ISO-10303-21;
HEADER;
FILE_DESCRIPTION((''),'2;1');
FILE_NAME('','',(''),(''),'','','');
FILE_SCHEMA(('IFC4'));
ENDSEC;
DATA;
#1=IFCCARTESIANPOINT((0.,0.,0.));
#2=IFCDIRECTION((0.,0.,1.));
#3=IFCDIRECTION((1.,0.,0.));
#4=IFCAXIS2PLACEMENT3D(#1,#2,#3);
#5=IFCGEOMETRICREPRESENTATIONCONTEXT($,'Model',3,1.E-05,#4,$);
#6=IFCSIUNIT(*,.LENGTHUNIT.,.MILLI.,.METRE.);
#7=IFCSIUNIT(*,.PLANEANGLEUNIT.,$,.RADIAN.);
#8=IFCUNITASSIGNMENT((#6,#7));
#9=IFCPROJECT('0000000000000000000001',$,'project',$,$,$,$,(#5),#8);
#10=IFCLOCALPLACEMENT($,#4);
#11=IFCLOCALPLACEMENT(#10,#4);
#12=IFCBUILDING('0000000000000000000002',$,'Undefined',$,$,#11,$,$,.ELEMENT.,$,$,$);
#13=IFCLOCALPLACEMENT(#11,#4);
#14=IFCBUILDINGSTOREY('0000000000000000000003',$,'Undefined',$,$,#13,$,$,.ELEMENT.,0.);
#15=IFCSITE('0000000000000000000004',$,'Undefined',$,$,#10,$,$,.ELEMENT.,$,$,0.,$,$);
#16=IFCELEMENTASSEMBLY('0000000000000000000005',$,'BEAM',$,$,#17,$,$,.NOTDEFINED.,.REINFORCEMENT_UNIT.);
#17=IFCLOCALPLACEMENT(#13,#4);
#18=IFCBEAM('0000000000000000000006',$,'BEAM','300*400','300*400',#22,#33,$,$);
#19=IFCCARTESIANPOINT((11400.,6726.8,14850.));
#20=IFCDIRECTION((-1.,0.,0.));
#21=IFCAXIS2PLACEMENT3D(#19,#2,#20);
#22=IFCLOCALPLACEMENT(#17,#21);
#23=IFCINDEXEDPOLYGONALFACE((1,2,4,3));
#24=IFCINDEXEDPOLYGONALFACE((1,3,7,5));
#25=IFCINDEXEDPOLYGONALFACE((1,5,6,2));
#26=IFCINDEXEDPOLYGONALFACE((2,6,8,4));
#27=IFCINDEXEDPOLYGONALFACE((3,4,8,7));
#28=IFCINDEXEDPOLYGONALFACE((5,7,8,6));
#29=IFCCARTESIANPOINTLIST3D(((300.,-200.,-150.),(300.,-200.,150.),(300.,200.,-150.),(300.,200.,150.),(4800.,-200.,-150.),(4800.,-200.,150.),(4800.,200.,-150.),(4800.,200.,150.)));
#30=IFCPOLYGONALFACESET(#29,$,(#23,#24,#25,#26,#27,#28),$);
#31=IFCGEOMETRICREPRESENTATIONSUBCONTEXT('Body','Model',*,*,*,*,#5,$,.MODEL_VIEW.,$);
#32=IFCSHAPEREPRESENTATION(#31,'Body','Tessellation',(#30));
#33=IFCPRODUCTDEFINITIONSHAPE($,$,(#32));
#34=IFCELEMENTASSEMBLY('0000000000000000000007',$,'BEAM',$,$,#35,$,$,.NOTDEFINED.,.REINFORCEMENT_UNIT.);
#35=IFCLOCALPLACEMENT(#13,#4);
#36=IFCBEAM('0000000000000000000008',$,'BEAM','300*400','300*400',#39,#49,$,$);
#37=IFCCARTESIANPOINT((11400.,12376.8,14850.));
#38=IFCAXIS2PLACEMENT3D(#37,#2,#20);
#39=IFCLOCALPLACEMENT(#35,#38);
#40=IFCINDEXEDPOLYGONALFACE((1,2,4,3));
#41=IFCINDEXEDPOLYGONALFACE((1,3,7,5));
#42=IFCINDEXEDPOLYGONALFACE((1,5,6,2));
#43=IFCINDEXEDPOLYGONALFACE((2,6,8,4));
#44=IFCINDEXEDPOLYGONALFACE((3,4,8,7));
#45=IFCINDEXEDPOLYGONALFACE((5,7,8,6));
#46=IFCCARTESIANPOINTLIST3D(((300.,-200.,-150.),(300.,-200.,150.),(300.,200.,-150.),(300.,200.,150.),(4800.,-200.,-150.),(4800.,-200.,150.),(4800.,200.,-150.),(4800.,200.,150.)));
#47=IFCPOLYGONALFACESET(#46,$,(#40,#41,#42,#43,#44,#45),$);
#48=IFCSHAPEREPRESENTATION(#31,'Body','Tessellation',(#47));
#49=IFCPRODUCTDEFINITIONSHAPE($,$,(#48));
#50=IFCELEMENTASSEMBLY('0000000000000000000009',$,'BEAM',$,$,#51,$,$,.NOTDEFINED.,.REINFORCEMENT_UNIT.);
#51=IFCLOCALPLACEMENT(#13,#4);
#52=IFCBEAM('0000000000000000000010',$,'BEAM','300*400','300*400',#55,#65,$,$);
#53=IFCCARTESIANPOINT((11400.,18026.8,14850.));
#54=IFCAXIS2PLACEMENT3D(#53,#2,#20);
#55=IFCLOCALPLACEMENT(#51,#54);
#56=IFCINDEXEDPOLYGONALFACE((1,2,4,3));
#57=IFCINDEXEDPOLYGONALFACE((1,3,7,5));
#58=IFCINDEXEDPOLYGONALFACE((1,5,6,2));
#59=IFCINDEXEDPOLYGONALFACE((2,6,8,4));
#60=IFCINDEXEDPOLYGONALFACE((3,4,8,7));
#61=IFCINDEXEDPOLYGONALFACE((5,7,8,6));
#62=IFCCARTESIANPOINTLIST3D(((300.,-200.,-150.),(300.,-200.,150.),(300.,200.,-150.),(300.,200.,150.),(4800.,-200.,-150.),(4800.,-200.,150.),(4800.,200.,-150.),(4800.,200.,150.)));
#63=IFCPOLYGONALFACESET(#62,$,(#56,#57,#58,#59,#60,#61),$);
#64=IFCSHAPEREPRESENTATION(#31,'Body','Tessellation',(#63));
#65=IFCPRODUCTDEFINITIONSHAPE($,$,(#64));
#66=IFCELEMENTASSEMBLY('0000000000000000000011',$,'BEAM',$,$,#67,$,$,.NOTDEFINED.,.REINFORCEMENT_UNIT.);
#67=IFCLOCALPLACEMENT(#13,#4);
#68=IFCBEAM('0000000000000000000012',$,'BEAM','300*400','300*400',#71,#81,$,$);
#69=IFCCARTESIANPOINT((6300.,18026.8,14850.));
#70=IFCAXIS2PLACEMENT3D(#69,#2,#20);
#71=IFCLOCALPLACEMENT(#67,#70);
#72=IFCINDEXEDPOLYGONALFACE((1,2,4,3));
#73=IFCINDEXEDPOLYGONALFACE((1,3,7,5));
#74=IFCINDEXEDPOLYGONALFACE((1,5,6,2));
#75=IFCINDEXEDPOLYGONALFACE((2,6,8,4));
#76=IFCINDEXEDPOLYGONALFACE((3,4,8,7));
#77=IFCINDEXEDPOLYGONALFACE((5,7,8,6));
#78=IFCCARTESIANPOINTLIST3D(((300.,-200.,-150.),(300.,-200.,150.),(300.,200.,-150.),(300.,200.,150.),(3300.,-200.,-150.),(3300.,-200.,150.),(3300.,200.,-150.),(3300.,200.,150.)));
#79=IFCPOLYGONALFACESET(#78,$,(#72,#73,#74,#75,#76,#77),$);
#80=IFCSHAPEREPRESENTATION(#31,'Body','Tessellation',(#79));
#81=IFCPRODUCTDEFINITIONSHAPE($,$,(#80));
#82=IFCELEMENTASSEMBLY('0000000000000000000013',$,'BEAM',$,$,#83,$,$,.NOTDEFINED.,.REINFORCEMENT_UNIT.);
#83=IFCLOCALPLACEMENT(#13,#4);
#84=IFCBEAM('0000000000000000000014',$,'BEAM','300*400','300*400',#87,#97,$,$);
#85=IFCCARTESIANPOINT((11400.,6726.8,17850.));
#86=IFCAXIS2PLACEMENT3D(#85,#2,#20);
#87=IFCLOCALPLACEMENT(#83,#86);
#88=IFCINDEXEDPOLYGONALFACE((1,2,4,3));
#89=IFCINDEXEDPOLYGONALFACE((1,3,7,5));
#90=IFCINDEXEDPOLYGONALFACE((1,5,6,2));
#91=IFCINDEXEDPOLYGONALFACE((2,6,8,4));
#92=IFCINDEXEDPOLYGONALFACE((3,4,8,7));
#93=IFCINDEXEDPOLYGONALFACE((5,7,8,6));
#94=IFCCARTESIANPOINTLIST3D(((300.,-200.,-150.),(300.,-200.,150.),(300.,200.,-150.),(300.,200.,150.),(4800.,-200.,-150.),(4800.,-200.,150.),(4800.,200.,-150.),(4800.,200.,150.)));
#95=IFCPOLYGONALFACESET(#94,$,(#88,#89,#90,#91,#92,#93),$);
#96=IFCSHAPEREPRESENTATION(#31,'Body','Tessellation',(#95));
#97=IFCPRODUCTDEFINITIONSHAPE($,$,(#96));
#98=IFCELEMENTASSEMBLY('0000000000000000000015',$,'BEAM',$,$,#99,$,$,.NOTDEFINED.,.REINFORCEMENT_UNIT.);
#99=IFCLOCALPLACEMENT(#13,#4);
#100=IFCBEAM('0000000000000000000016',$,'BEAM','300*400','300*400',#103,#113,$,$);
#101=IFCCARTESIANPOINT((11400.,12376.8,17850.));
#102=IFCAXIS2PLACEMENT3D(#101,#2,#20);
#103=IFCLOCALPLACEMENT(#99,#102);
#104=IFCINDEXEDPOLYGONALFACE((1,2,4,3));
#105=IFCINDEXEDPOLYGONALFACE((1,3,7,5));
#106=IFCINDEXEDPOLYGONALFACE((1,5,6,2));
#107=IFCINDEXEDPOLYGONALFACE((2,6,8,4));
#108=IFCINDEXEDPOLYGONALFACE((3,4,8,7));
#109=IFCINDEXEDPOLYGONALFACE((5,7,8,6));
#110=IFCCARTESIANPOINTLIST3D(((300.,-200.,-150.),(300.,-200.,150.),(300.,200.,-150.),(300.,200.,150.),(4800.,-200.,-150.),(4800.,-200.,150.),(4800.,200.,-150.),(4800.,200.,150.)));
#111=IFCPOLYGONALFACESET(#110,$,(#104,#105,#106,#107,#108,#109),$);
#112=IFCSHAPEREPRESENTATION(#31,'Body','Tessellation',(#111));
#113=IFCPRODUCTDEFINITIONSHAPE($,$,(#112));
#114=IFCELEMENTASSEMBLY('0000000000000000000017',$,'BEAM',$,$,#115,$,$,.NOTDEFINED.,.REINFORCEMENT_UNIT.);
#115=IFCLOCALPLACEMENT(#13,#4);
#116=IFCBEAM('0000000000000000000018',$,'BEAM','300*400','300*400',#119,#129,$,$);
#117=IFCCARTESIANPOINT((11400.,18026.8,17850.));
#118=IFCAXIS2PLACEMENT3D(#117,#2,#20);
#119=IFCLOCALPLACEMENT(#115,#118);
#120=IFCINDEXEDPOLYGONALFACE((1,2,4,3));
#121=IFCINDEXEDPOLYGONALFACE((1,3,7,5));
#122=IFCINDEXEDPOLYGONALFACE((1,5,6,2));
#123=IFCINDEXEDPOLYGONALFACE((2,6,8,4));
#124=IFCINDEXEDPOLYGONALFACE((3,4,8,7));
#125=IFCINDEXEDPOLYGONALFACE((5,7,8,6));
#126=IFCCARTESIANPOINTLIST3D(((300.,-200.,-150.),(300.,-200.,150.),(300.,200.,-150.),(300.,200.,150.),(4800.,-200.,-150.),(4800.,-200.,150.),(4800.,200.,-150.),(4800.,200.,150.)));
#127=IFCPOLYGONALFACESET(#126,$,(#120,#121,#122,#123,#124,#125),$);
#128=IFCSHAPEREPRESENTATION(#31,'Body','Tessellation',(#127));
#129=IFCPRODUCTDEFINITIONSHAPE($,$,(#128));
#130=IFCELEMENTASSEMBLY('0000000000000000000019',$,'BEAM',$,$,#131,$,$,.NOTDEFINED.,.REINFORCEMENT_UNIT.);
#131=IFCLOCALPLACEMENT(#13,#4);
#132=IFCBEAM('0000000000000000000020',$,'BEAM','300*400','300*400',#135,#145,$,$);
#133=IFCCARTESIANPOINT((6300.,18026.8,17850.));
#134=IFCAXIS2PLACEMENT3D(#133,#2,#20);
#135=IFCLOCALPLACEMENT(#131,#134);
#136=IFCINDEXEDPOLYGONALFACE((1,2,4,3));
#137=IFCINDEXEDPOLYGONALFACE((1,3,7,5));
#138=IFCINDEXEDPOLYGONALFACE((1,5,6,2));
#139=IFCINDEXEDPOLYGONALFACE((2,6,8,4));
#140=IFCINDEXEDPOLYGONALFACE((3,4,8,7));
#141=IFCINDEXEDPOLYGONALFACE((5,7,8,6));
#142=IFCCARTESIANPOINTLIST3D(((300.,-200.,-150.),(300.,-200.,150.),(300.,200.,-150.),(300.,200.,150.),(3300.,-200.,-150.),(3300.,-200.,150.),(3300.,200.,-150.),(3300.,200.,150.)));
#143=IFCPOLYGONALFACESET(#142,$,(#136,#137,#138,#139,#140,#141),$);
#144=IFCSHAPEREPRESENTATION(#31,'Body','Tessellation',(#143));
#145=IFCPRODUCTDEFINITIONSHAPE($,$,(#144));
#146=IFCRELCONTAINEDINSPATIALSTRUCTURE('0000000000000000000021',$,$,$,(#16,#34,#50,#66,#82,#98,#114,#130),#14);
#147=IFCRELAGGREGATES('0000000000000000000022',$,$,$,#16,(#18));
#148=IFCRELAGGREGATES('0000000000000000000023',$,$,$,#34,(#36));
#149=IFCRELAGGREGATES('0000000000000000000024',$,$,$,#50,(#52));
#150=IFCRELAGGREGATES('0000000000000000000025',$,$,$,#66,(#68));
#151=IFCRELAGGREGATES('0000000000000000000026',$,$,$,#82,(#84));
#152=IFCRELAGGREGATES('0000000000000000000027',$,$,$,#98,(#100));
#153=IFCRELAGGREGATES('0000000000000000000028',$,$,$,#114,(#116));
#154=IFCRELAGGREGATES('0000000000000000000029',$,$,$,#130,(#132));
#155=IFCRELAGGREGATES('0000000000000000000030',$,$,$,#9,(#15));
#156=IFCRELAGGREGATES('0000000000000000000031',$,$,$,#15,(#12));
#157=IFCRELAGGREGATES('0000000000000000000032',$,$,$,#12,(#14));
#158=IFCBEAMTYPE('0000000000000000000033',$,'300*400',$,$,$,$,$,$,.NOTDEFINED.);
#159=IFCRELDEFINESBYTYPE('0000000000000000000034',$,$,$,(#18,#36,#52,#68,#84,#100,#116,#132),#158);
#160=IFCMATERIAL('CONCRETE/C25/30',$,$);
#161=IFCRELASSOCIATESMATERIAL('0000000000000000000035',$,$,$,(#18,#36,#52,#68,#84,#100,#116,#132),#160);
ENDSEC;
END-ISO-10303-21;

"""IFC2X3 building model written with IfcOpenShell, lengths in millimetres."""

from ifc_helpers import new_model, si_unit, frame, origin_with_axes, origin_2d_with_axis, place, context, subcontext, project, spatial, rectangle, extrude, material, type_object, element, aggregate, save


model = new_model("IFC2X3")

# Units and contexts
model_context = context("Model", 3, precision=1e-05, world=origin_with_axes())
body_context = subcontext(model_context, "Body", "Model", "MODEL_VIEW")
ifc_project = project(units=[si_unit("LENGTHUNIT", "METRE", prefix="MILLI"), si_unit("PLANEANGLEUNIT", "RADIAN")], contexts=[model_context])

# Site, building, storey
site_placement = place(None, origin_with_axes())
site = spatial("IfcSite", under=ifc_project, at=site_placement, Name="Undefined", CompositionType="ELEMENT", RefElevation=0.0)
building_placement = place(site_placement, origin_with_axes())
building = spatial("IfcBuilding", under=site, at=building_placement, Name="Undefined", CompositionType="ELEMENT")
storey_placement = place(building_placement, origin_with_axes())
storey = spatial("IfcBuildingStorey", under=building, at=storey_placement, Name="Undefined", CompositionType="ELEMENT", Elevation=0.0)

# Shared definitions
ifc_material = material(Name="CONCRETE/C25/30")

# Element assemblies, beams
beam_type_1 = type_object("IfcBeamType", Name="300*400", PredefinedType="NOTDEFINED")
assembly_1_placement = place(storey_placement, origin_with_axes())
assembly_1 = element("IfcElementAssembly", 1, at=assembly_1_placement, inside=storey, Name="BEAM", AssemblyPlace="NOTDEFINED", PredefinedType="REINFORCEMENT_UNIT")
beam_1_placement = place(assembly_1_placement, frame((11400.0, 6726.8, 14850.0), z_axis=(0.0, 0.0, 1.0), x_axis=(-1.0, 0.0, 0.0)))
beam_1 = element("IfcBeam", 2, at=beam_1_placement, type_object=beam_type_1, material=ifc_material, Name="BEAM", Description="300*400", ObjectType="300*400", context=body_context, shape_type="SweptSolid", body=[
    extrude(rectangle(XDim=400.0, YDim=300.0, at=origin_2d_with_axis()), frame((4800.0, 0.0, 0.0), z_axis=(-1.0, 0.0, 0.0), x_axis=(0.0, -1.0, 0.0)), (0.0, 0.0, 1.0), 4500.0),
])
aggregate(assembly_1, [beam_1])
assembly_2_placement = place(storey_placement, origin_with_axes())
assembly_2 = element("IfcElementAssembly", 3, at=assembly_2_placement, inside=storey, Name="BEAM", AssemblyPlace="NOTDEFINED", PredefinedType="REINFORCEMENT_UNIT")
beam_2_placement = place(assembly_2_placement, frame((11400.0, 12376.8, 14850.0), z_axis=(0.0, 0.0, 1.0), x_axis=(-1.0, 0.0, 0.0)))
beam_2 = element("IfcBeam", 4, at=beam_2_placement, type_object=beam_type_1, material=ifc_material, Name="BEAM", Description="300*400", ObjectType="300*400", context=body_context, shape_type="SweptSolid", body=[
    extrude(rectangle(XDim=400.0, YDim=300.0, at=origin_2d_with_axis()), frame((4800.0, 0.0, 0.0), z_axis=(-1.0, 0.0, 0.0), x_axis=(0.0, -1.0, 0.0)), (0.0, 0.0, 1.0), 4500.0),
])
aggregate(assembly_2, [beam_2])
assembly_3_placement = place(storey_placement, origin_with_axes())
assembly_3 = element("IfcElementAssembly", 5, at=assembly_3_placement, inside=storey, Name="BEAM", AssemblyPlace="NOTDEFINED", PredefinedType="REINFORCEMENT_UNIT")
beam_3_placement = place(assembly_3_placement, frame((11400.0, 18026.8, 14850.0), z_axis=(0.0, 0.0, 1.0), x_axis=(-1.0, 0.0, 0.0)))
beam_3 = element("IfcBeam", 6, at=beam_3_placement, type_object=beam_type_1, material=ifc_material, Name="BEAM", Description="300*400", ObjectType="300*400", context=body_context, shape_type="SweptSolid", body=[
    extrude(rectangle(XDim=400.0, YDim=300.0, at=origin_2d_with_axis()), frame((4800.0, 0.0, 0.0), z_axis=(-1.0, 0.0, 0.0), x_axis=(0.0, -1.0, 0.0)), (0.0, 0.0, 1.0), 4500.0),
])
aggregate(assembly_3, [beam_3])
assembly_4_placement = place(storey_placement, origin_with_axes())
assembly_4 = element("IfcElementAssembly", 7, at=assembly_4_placement, inside=storey, Name="BEAM", AssemblyPlace="NOTDEFINED", PredefinedType="REINFORCEMENT_UNIT")
beam_4_placement = place(assembly_4_placement, frame((6300.0, 18026.8, 14850.0), z_axis=(0.0, 0.0, 1.0), x_axis=(-1.0, 0.0, 0.0)))
beam_4 = element("IfcBeam", 8, at=beam_4_placement, type_object=beam_type_1, material=ifc_material, Name="BEAM", Description="300*400", ObjectType="300*400", context=body_context, shape_type="SweptSolid", body=[
    extrude(rectangle(XDim=400.0, YDim=300.0, at=origin_2d_with_axis()), frame((3300.0, 0.0, 0.0), z_axis=(-1.0, 0.0, 0.0), x_axis=(0.0, -1.0, 0.0)), (0.0, 0.0, 1.0), 3000.0),
])
aggregate(assembly_4, [beam_4])
assembly_5_placement = place(storey_placement, origin_with_axes())
assembly_5 = element("IfcElementAssembly", 9, at=assembly_5_placement, inside=storey, Name="BEAM", AssemblyPlace="NOTDEFINED", PredefinedType="REINFORCEMENT_UNIT")
beam_5_placement = place(assembly_5_placement, frame((11400.0, 6726.8, 17850.0), z_axis=(0.0, 0.0, 1.0), x_axis=(-1.0, 0.0, 0.0)))
beam_5 = element("IfcBeam", 10, at=beam_5_placement, type_object=beam_type_1, material=ifc_material, Name="BEAM", Description="300*400", ObjectType="300*400", context=body_context, shape_type="SweptSolid", body=[
    extrude(rectangle(XDim=400.0, YDim=300.0, at=origin_2d_with_axis()), frame((4800.0, 0.0, 0.0), z_axis=(-1.0, 0.0, 0.0), x_axis=(0.0, -1.0, 0.0)), (0.0, 0.0, 1.0), 4500.0),
])
aggregate(assembly_5, [beam_5])
assembly_6_placement = place(storey_placement, origin_with_axes())
assembly_6 = element("IfcElementAssembly", 11, at=assembly_6_placement, inside=storey, Name="BEAM", AssemblyPlace="NOTDEFINED", PredefinedType="REINFORCEMENT_UNIT")
beam_6_placement = place(assembly_6_placement, frame((11400.0, 12376.8, 17850.0), z_axis=(0.0, 0.0, 1.0), x_axis=(-1.0, 0.0, 0.0)))
beam_6 = element("IfcBeam", 12, at=beam_6_placement, type_object=beam_type_1, material=ifc_material, Name="BEAM", Description="300*400", ObjectType="300*400", context=body_context, shape_type="SweptSolid", body=[
    extrude(rectangle(XDim=400.0, YDim=300.0, at=origin_2d_with_axis()), frame((4800.0, 0.0, 0.0), z_axis=(-1.0, 0.0, 0.0), x_axis=(0.0, -1.0, 0.0)), (0.0, 0.0, 1.0), 4500.0),
])
aggregate(assembly_6, [beam_6])
assembly_7_placement = place(storey_placement, origin_with_axes())
assembly_7 = element("IfcElementAssembly", 13, at=assembly_7_placement, inside=storey, Name="BEAM", AssemblyPlace="NOTDEFINED", PredefinedType="REINFORCEMENT_UNIT")
beam_7_placement = place(assembly_7_placement, frame((11400.0, 18026.8, 17850.0), z_axis=(0.0, 0.0, 1.0), x_axis=(-1.0, 0.0, 0.0)))
beam_7 = element("IfcBeam", 14, at=beam_7_placement, type_object=beam_type_1, material=ifc_material, Name="BEAM", Description="300*400", ObjectType="300*400", context=body_context, shape_type="SweptSolid", body=[
    extrude(rectangle(XDim=400.0, YDim=300.0, at=origin_2d_with_axis()), frame((4800.0, 0.0, 0.0), z_axis=(-1.0, 0.0, 0.0), x_axis=(0.0, -1.0, 0.0)), (0.0, 0.0, 1.0), 4500.0),
])
aggregate(assembly_7, [beam_7])
assembly_8_placement = place(storey_placement, origin_with_axes())
assembly_8 = element("IfcElementAssembly", 15, at=assembly_8_placement, inside=storey, Name="BEAM", AssemblyPlace="NOTDEFINED", PredefinedType="REINFORCEMENT_UNIT")
beam_8_placement = place(assembly_8_placement, frame((6300.0, 18026.8, 17850.0), z_axis=(0.0, 0.0, 1.0), x_axis=(-1.0, 0.0, 0.0)))
beam_8 = element("IfcBeam", 16, at=beam_8_placement, type_object=beam_type_1, material=ifc_material, Name="BEAM", Description="300*400", ObjectType="300*400", context=body_context, shape_type="SweptSolid", body=[
    extrude(rectangle(XDim=400.0, YDim=300.0, at=origin_2d_with_axis()), frame((3300.0, 0.0, 0.0), z_axis=(-1.0, 0.0, 0.0), x_axis=(0.0, -1.0, 0.0)), (0.0, 0.0, 1.0), 3000.0),
])
aggregate(assembly_8, [beam_8])

save(model, "model.ifc")
